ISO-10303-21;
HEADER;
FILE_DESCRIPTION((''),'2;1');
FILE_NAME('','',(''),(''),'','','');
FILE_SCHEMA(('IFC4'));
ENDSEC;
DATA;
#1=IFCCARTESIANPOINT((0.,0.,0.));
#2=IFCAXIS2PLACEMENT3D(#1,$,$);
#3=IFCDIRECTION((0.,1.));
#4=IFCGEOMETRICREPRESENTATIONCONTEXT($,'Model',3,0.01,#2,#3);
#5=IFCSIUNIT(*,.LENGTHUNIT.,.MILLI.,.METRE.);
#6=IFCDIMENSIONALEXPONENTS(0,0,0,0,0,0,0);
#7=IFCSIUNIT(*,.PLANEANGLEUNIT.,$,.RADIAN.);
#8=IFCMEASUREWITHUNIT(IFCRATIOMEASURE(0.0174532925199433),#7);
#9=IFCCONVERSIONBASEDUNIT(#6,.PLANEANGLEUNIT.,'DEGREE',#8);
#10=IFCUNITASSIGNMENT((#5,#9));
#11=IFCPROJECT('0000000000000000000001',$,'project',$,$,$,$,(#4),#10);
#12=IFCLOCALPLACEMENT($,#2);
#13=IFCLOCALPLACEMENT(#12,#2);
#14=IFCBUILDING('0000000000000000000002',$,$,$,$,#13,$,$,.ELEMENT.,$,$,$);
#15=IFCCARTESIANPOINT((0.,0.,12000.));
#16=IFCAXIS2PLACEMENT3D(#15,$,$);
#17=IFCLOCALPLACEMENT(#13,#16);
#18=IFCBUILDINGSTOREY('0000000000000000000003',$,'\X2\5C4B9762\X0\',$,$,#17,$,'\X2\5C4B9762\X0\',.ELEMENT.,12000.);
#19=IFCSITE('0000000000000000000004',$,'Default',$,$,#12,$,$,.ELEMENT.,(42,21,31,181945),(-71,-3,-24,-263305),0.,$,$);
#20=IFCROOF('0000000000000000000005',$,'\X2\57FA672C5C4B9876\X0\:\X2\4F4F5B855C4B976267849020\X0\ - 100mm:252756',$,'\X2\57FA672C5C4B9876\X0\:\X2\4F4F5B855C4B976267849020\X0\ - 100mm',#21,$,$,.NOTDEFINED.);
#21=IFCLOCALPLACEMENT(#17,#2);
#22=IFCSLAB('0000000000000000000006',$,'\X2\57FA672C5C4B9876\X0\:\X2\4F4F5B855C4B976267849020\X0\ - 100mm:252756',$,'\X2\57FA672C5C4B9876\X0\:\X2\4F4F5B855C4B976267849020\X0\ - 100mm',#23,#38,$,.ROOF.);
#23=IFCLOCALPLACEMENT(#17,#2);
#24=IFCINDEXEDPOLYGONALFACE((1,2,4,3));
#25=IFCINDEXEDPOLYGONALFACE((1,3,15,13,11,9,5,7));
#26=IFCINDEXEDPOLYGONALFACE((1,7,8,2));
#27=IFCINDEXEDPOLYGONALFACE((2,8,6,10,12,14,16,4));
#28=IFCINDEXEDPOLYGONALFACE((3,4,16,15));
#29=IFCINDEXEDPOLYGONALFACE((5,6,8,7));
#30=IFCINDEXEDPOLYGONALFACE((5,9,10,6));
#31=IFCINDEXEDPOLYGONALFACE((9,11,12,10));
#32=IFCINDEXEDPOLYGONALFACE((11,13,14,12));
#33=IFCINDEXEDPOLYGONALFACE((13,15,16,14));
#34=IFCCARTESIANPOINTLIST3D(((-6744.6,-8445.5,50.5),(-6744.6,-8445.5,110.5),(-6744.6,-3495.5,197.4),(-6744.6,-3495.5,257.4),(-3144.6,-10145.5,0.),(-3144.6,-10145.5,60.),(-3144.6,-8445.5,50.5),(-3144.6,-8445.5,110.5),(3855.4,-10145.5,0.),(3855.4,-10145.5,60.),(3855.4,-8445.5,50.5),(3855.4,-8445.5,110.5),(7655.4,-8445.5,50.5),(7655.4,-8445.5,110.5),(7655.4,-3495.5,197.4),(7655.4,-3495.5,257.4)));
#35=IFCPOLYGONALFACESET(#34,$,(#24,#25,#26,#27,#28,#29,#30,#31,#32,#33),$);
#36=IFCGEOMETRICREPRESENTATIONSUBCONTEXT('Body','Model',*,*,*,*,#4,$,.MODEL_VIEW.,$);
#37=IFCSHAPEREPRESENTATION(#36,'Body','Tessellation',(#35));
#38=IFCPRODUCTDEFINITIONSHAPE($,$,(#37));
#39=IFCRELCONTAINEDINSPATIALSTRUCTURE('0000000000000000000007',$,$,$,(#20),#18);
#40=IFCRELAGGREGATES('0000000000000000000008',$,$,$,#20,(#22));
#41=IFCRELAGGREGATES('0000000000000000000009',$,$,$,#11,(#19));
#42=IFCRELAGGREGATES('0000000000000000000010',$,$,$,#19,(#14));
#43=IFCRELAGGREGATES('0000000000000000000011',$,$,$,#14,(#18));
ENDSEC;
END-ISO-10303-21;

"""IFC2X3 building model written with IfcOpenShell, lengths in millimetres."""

from ifc_helpers import new_model, entity, si_unit, converted_unit, direction, frame, origin, place, context, subcontext, project, spatial, polyline, outline, extrude, element, aggregate, save


model = new_model("IFC2X3")

# Units and contexts
model_context = context("Model", 3, precision=0.01, world=origin(), true_north=direction((0.0, 1.0)))
body_context = subcontext(model_context, "Body", "Model", "MODEL_VIEW")
ifc_project = project(units=[si_unit("LENGTHUNIT", "METRE", prefix="MILLI"), converted_unit("PLANEANGLEUNIT", "DEGREE", entity("IfcRatioMeasure", 0.0174532925199433), si_unit("PLANEANGLEUNIT", "RADIAN"), dimensions=[0, 0, 0, 0, 0, 0, 0])], contexts=[model_context])

# Site, building, storey
site_placement = place(None, origin())
site = spatial("IfcSite", under=ifc_project, at=site_placement, Name="Default", CompositionType="ELEMENT", RefLatitude=(42, 21, 31, 181945), RefLongitude=(-71, -3, -24, -263305), RefElevation=0.0)
building_placement = place(site_placement, origin())
building = spatial("IfcBuilding", under=site, at=building_placement, CompositionType="ELEMENT")
storey_placement = place(building_placement, frame((0.0, 0.0, 12000.0)))
storey = spatial("IfcBuildingStorey", under=building, at=storey_placement, Name="屋面", LongName="屋面", CompositionType="ELEMENT", Elevation=12000.0)

# Roof, slab
roof_placement = place(storey_placement, frame((-6744.6, -10145.5, 0.0)))
roof = element("IfcRoof", 1, at=roof_placement, inside=storey, Name="基本屋顶:住宅屋面构造 - 100mm:252756", ObjectType="基本屋顶:住宅屋面构造 - 100mm", ShapeType="NOTDEFINED")
slab_1_placement = place(roof_placement, origin())
slab_1 = element("IfcSlab", 2, at=slab_1_placement, Name="基本屋顶:住宅屋面构造 - 100mm:252756", ObjectType="基本屋顶:住宅屋面构造 - 100mm", PredefinedType="ROOF", context=body_context, shape_type="SweptSolid", body=[
    extrude(outline(polyline([(-3600.0, -1625.7), (-3600.0, -3326.5), (3400.0, -3326.5), (3400.0, -1625.7), (7200.0, -1625.7), (7200.0, 3326.5), (-7200.0, 3326.5), (-7200.0, -1625.7), (-3600.0, -1625.7)])), frame((7200.0, 3325.0, 98.7), z_axis=(0.0, -0.029666, 0.99956), x_axis=(1.0, 0.0, 0.0)), (0.0, 0.029666, 0.99956), 60.0),
])
aggregate(roof, [slab_1])

save(model, "model.ifc")
